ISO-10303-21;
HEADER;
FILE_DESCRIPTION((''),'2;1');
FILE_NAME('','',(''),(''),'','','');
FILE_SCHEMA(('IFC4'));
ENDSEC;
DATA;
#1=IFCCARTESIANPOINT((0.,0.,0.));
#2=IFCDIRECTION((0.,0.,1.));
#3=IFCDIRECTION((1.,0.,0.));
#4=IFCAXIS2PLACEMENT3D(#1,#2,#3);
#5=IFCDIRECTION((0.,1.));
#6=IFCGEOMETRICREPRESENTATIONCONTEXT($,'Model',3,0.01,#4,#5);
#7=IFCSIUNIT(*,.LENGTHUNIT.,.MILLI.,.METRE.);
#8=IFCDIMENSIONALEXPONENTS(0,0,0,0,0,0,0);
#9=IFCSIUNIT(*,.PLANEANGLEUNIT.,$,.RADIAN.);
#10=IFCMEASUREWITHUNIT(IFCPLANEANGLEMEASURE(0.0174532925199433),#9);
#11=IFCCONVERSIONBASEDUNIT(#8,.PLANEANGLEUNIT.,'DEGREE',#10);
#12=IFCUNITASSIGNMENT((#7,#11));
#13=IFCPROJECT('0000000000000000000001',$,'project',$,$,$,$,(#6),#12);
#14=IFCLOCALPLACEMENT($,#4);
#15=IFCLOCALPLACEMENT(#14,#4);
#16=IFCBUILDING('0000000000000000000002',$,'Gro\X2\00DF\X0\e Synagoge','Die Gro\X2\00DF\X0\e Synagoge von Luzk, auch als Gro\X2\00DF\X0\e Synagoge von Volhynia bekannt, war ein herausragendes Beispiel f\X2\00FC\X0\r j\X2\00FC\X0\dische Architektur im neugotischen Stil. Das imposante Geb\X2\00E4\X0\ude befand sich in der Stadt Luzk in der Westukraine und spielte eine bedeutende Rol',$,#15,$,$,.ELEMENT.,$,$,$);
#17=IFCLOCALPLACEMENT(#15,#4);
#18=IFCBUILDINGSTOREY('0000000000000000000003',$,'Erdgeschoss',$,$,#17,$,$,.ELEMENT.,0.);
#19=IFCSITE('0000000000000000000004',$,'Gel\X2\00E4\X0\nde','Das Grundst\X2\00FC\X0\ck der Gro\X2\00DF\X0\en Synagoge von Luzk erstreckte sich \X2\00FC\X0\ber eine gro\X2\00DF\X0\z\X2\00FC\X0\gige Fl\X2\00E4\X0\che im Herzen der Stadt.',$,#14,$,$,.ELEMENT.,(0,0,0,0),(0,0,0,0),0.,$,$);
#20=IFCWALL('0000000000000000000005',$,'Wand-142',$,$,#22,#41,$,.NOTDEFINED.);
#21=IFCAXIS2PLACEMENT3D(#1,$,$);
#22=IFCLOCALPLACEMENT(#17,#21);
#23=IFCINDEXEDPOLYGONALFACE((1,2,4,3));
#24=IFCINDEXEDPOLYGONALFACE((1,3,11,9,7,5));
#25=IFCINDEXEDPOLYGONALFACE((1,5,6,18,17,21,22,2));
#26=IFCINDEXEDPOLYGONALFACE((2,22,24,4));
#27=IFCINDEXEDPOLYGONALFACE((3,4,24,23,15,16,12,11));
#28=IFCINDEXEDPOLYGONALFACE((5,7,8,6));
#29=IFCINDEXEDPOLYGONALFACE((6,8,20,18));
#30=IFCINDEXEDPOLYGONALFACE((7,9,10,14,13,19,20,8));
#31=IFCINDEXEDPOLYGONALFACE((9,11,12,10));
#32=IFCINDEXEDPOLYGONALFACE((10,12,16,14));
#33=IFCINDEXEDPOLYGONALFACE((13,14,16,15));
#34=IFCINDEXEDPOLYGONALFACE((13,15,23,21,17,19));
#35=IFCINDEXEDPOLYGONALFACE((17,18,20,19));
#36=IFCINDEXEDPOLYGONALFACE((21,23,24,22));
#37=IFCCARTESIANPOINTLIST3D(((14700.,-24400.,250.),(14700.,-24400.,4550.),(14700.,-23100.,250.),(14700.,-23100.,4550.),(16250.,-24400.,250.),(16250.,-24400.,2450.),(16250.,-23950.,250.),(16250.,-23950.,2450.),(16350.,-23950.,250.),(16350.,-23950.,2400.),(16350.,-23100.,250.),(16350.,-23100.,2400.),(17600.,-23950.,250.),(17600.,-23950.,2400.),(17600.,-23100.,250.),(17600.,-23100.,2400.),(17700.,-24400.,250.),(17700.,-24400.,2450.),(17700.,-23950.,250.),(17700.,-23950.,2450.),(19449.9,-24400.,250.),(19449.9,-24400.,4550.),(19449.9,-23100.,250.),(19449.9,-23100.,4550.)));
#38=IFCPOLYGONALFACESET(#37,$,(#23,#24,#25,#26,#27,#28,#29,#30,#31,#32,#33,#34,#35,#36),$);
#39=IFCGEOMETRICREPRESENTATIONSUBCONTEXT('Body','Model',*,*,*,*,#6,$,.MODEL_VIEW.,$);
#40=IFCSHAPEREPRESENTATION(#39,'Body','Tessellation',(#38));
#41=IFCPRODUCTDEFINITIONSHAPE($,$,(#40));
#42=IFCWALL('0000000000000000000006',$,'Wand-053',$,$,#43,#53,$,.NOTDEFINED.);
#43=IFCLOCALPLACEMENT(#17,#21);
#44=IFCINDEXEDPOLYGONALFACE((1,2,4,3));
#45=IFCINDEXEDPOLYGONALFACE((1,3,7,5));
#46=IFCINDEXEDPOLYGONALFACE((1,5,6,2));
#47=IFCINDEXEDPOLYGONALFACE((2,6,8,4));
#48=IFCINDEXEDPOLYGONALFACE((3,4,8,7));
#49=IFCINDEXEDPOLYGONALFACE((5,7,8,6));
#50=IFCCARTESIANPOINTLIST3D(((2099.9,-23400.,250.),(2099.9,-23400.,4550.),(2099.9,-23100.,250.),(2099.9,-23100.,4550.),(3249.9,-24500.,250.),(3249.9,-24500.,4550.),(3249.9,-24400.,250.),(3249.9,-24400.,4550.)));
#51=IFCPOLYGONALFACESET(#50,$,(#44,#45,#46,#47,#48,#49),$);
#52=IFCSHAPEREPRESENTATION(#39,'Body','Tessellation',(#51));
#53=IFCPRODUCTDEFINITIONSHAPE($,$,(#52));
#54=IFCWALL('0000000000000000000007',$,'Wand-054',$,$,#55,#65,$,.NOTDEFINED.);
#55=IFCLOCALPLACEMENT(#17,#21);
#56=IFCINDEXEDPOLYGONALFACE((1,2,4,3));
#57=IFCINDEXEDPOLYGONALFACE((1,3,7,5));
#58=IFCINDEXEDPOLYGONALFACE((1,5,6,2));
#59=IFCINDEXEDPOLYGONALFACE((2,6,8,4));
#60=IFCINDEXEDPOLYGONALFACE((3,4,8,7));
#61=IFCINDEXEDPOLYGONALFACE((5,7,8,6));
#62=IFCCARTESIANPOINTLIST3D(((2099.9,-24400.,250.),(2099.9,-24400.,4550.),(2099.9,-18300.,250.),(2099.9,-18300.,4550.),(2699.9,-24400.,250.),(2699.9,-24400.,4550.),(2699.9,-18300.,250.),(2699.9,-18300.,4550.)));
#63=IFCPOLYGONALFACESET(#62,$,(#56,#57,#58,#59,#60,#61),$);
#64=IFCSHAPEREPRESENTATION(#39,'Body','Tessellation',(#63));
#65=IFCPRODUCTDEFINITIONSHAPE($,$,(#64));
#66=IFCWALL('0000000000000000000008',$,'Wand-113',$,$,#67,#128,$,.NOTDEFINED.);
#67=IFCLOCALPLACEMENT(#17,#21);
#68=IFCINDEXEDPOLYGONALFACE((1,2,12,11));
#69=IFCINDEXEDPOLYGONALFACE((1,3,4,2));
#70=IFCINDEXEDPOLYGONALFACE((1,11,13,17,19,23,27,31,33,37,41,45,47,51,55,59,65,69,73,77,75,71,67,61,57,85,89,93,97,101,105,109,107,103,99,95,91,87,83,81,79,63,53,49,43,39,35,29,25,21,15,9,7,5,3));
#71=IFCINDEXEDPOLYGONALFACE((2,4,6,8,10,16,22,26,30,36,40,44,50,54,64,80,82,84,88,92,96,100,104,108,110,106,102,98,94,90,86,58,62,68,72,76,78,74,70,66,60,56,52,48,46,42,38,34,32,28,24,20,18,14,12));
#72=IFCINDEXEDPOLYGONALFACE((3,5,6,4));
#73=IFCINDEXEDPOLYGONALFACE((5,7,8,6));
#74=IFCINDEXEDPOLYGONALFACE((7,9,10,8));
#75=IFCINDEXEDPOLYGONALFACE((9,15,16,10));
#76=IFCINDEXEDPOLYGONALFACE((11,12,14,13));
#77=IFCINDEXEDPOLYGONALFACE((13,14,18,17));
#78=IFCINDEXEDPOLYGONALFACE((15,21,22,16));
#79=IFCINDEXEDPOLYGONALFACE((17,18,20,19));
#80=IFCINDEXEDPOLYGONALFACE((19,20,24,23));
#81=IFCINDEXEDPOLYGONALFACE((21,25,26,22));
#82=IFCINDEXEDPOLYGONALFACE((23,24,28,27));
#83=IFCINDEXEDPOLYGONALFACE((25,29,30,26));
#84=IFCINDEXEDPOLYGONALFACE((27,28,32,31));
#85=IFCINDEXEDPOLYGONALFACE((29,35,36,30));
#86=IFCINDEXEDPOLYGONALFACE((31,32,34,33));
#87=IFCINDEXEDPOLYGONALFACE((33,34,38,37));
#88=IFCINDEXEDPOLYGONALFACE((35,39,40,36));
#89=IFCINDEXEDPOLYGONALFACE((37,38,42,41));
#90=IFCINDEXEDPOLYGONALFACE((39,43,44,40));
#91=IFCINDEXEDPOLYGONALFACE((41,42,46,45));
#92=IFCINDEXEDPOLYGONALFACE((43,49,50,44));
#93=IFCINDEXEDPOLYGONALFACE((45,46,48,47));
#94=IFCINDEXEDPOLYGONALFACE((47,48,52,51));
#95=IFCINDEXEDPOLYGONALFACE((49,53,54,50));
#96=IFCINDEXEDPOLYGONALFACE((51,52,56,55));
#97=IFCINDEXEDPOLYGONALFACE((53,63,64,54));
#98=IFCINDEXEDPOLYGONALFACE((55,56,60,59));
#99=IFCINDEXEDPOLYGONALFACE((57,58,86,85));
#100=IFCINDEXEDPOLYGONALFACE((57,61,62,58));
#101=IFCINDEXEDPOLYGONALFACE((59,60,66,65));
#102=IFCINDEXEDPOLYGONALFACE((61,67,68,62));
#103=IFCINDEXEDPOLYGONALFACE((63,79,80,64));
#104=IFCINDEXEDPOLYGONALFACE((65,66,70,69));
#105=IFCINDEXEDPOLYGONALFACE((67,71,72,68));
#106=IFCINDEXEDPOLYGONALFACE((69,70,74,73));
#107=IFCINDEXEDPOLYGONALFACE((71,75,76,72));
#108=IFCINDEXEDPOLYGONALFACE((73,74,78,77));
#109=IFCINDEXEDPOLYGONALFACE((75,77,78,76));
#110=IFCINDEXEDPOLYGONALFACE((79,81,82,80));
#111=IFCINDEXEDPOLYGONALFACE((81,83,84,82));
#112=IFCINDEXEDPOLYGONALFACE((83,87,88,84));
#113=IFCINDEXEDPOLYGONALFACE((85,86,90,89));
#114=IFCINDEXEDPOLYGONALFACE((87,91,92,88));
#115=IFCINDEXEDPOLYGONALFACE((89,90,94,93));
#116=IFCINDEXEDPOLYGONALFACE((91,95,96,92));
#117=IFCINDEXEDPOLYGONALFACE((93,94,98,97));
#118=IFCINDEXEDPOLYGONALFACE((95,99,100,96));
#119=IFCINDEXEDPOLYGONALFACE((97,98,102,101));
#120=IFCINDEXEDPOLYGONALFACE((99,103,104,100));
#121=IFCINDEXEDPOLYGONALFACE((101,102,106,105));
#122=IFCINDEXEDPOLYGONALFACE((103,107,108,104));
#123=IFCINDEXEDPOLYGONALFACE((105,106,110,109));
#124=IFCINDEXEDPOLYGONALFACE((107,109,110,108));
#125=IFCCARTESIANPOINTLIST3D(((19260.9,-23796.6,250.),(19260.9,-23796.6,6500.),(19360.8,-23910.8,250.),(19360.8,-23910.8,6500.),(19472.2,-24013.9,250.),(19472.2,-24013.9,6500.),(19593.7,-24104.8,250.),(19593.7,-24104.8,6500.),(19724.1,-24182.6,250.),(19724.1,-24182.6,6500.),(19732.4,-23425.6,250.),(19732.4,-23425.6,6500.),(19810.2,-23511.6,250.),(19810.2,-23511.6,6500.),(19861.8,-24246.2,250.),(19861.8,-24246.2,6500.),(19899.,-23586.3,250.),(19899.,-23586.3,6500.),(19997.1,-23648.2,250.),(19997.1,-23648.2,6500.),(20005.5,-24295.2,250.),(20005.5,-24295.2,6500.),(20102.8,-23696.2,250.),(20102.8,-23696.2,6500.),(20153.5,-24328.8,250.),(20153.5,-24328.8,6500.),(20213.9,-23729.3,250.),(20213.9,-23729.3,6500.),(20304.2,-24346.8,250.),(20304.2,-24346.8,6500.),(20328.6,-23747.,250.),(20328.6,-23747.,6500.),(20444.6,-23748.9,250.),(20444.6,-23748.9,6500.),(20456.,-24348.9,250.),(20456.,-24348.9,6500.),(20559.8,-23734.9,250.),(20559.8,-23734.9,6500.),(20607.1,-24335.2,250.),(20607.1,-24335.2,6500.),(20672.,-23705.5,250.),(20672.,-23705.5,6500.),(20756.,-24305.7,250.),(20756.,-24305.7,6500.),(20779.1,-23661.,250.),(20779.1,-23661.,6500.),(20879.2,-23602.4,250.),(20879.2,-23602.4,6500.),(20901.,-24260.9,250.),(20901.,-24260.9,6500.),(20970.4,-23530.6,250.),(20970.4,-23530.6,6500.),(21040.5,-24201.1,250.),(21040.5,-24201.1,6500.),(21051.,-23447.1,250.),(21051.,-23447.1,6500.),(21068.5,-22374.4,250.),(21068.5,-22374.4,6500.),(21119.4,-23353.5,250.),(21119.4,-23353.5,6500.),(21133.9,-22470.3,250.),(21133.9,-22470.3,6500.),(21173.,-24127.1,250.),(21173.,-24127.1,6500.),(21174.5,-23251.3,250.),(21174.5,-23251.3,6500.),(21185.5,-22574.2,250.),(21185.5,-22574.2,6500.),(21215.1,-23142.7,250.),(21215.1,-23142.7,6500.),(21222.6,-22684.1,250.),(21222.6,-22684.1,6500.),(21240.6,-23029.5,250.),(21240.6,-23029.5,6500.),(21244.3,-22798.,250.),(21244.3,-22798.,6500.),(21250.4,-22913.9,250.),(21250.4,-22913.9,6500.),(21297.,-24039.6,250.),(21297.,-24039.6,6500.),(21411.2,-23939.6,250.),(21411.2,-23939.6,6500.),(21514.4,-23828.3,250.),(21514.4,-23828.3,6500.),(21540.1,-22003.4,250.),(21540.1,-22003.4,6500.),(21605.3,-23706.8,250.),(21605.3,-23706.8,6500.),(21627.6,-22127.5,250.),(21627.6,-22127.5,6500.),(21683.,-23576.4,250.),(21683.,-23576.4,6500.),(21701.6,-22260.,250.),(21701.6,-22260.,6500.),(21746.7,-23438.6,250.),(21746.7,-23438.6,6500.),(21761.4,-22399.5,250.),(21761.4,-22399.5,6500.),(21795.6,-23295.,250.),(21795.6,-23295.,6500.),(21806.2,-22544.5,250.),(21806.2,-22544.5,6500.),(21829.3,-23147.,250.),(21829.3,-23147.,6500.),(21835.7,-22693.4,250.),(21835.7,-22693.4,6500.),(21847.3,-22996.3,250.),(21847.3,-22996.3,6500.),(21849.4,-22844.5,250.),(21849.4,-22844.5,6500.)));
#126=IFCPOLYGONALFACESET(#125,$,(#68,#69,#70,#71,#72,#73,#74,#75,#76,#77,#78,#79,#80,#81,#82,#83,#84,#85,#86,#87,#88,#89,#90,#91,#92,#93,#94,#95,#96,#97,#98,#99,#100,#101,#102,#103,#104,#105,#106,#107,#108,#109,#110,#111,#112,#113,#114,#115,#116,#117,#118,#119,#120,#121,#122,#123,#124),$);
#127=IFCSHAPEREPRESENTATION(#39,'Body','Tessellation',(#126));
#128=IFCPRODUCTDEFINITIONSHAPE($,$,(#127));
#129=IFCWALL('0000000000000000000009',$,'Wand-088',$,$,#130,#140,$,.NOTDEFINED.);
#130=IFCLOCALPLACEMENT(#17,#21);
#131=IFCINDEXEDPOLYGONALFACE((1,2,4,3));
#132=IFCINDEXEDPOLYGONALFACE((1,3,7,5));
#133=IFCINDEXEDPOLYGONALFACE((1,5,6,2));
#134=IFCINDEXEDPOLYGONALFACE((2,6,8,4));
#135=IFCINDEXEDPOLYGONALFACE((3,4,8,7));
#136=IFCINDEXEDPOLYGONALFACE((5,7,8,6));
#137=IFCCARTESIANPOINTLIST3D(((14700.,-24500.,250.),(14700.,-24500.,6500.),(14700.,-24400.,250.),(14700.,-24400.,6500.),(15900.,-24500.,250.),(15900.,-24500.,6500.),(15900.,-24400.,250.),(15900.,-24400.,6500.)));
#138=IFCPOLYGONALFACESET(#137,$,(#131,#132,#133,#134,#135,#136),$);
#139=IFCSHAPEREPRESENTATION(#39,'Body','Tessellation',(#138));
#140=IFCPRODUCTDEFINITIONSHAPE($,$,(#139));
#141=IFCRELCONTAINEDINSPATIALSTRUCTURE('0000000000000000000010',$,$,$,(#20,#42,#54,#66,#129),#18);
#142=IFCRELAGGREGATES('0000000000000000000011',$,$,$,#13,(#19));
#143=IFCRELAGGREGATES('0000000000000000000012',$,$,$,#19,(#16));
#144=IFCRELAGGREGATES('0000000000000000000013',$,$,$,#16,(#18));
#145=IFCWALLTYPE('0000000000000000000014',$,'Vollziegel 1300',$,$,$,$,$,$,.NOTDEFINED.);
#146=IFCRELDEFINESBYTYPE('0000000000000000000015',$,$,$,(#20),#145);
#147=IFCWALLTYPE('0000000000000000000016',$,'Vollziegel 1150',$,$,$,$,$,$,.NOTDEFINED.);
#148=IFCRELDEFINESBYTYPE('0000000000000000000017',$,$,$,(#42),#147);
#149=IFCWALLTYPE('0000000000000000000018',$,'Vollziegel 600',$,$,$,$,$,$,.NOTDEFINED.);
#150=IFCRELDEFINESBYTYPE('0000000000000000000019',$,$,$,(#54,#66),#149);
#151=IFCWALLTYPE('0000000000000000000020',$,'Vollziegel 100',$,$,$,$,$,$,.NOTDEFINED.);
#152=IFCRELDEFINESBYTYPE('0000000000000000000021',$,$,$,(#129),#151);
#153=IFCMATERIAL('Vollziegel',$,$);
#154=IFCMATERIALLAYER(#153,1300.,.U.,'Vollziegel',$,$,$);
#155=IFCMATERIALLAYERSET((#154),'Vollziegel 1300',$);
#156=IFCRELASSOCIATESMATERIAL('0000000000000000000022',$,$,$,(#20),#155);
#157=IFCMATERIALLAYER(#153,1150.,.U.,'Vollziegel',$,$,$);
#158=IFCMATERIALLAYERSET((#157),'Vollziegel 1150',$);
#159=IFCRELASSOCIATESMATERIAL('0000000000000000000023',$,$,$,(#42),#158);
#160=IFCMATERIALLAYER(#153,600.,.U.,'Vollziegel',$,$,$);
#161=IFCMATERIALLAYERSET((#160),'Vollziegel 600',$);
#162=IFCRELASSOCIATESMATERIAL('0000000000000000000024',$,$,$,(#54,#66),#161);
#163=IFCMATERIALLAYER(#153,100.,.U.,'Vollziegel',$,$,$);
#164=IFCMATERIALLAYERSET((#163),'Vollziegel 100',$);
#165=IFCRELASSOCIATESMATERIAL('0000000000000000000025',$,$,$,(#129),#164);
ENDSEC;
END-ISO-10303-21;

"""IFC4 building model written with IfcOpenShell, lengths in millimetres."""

from ifc_helpers import new_model, entity, si_unit, converted_unit, direction, frame, origin_with_axes, origin_2d_with_axis, place, context, subcontext, project, spatial, line, arc, indexed_curve, rectangle, outline, extrude, material, layer, layer_set, layer_usage, type_object, element, save


model = new_model("IFC4")

# Units and contexts
model_context = context("Model", 3, precision=0.01, world=origin_with_axes(), true_north=direction((0.0, 1.0)))
body_context = subcontext(model_context, "Body", "Model", "MODEL_VIEW")
ifc_project = project(units=[si_unit("LENGTHUNIT", "METRE", prefix="MILLI"), converted_unit("PLANEANGLEUNIT", "DEGREE", entity("IfcPlaneAngleMeasure", 0.0174532925199433), si_unit("PLANEANGLEUNIT", "RADIAN"), dimensions=[0, 0, 0, 0, 0, 0, 0])], contexts=[model_context])

# Site, building, storey
site_placement = place(None, origin_with_axes())
site = spatial("IfcSite", under=ifc_project, at=site_placement, Name="Gelände", Description="Das Grundstück der Großen Synagoge von Luzk erstreckte sich über eine großzügige Fläche im Herzen der Stadt.", CompositionType="ELEMENT", RefLatitude=(0, 0, 0, 0), RefLongitude=(0, 0, 0, 0), RefElevation=0.0)
building_placement = place(site_placement, origin_with_axes())
building = spatial("IfcBuilding", under=site, at=building_placement, Name="Große Synagoge", Description="Die Große Synagoge von Luzk, auch als Große Synagoge von Volhynia bekannt, war ein herausragendes Beispiel für jüdische Architektur im neugotischen Stil. Das imposante Gebäude befand sich in der Stadt Luzk in der Westukraine und spielte eine bedeutende Rol", CompositionType="ELEMENT")
storey_placement = place(building_placement, origin_with_axes())
storey = spatial("IfcBuildingStorey", under=building, at=storey_placement, Name="Erdgeschoss", CompositionType="ELEMENT", Elevation=0.0)

# Wall, opening
ifc_material_1 = material(Name="Vollziegel")
ifc_layer_1 = layer(ifc_material_1, 1300.0, ventilated="UNKNOWN", Name="Vollziegel")
ifc_layer_set_1 = layer_set([ifc_layer_1], Name="Vollziegel 1300")
ifc_layer_usage_1 = layer_usage(ifc_layer_set_1, "AXIS2", "POSITIVE", 0.0)
wall_type_1 = type_object("IfcWallType", Name="Vollziegel 1300", PredefinedType="NOTDEFINED")
wall_1_placement = place(storey_placement, frame((14700.0, -24400.0, 250.0), z_axis=(0.0, 0.0, 1.0), x_axis=(1.0, 0.0, 0.0)))
wall_1 = element("IfcWall", 1, at=wall_1_placement, inside=storey, type_object=wall_type_1, material=ifc_layer_usage_1, Name="Wand-142", PredefinedType="NOTDEFINED", context=body_context, shape_type="SweptSolid", body=[
    extrude(outline(indexed_curve([(0.0, 0.0), (4749.9, 0.0), (4749.9, 1300.0), (0.0, 1300.0)], segments=[line(1, 2, 3, 4, 1)])), origin_with_axes(), (0.0, 0.0, 1.0), 4300.0),
])
opening_placement = place(wall_1_placement, frame((2275.0, 0.0, 0.0), z_axis=(0.0, 0.0, 1.0), x_axis=(1.0, 0.0, 0.0)))
element("IfcOpeningElement", 2, at=opening_placement, cuts=wall_1, context=body_context, shape_type="SweptSolid", body=[
    extrude(rectangle(XDim=1250.0, YDim=2400.0, at=origin_2d_with_axis()), frame((0.0, 450.0, 950.0), z_axis=(0.0, -1.0, 0.0), x_axis=(1.0, 0.0, 0.0)), (0.0, 0.0, -1.0), 2150.0),
    extrude(rectangle(XDim=1450.0, YDim=2450.0, at=origin_2d_with_axis()), frame((0.0, 450.0, 975.0), z_axis=(0.0, 1.0, 0.0), x_axis=(1.0, 0.0, 0.0)), (0.0, 0.0, -1.0), 1750.0),
])

# Walls
ifc_layer_2 = layer(ifc_material_1, 1150.0, ventilated="UNKNOWN", Name="Vollziegel")
ifc_layer_set_2 = layer_set([ifc_layer_2], Name="Vollziegel 1150")
ifc_layer_usage_2 = layer_usage(ifc_layer_set_2, "AXIS2", "POSITIVE", -1150.0)
wall_type_2 = type_object("IfcWallType", Name="Vollziegel 1150", PredefinedType="NOTDEFINED")
wall_2_placement = place(storey_placement, frame((2099.9, -24500.0, 250.0), z_axis=(0.0, 0.0, 1.0), x_axis=(0.0, 1.0, 0.0)))
element("IfcWall", 3, at=wall_2_placement, inside=storey, type_object=wall_type_2, material=ifc_layer_usage_2, Name="Wand-053", PredefinedType="NOTDEFINED", context=body_context, shape_type="SweptSolid", body=[
    extrude(outline(indexed_curve([(0.0, -1150.0), (100.0, -1150.0), (1400.0, 0.0), (1100.0, 0.0)], segments=[line(1, 2, 3, 4, 1)])), origin_with_axes(), (0.0, 0.0, 1.0), 4300.0),
])
ifc_layer_3 = layer(ifc_material_1, 600.0, ventilated="UNKNOWN", Name="Vollziegel")
ifc_layer_set_3 = layer_set([ifc_layer_3], Name="Vollziegel 600")
ifc_layer_usage_3 = layer_usage(ifc_layer_set_3, "AXIS2", "POSITIVE", -600.0)
wall_type_3 = type_object("IfcWallType", Name="Vollziegel 600", PredefinedType="NOTDEFINED")
wall_3_placement = place(storey_placement, frame((2099.9, -24400.0, 250.0), z_axis=(0.0, 0.0, 1.0), x_axis=(0.0, 1.0, 0.0)))
element("IfcWall", 4, at=wall_3_placement, inside=storey, type_object=wall_type_3, material=ifc_layer_usage_3, Name="Wand-054", PredefinedType="NOTDEFINED", context=body_context, shape_type="SweptSolid", body=[
    extrude(outline(indexed_curve([(0.0, -600.0), (6100.0, -600.0), (6100.0, 0.0), (0.0, 0.0)], segments=[line(1, 2, 3, 4, 1)])), origin_with_axes(), (0.0, 0.0, 1.0), 4300.0),
])
ifc_layer_usage_4 = layer_usage(ifc_layer_set_3, "AXIS2", "POSITIVE", -600.0)
wall_4_placement = place(storey_placement, frame((19732.4, -23425.6, 250.0), z_axis=(0.0, 0.0, 1.0), x_axis=(0.618314, -0.785931, 0.0)))
element("IfcWall", 5, at=wall_4_placement, inside=storey, type_object=wall_type_3, material=ifc_layer_usage_4, Name="Wand-113", PredefinedType="NOTDEFINED", context=body_context, shape_type="SweptSolid", body=[
    extrude(outline(indexed_curve([(0.0, -600.0), (1450.0, 850.0), (0.0, 2300.0), (0.0, 1700.0), (850.0, 850.0), (0.0, 0.0)], segments=[arc(1, 2, 3), line(3, 4), arc(4, 5, 6), line(6, 1)])), origin_with_axes(), (0.0, 0.0, 1.0), 6250.0),
])
ifc_layer_4 = layer(ifc_material_1, 100.0, ventilated="UNKNOWN", Name="Vollziegel")
ifc_layer_set_4 = layer_set([ifc_layer_4], Name="Vollziegel 100")
ifc_layer_usage_5 = layer_usage(ifc_layer_set_4, "AXIS2", "POSITIVE", 0.0)
wall_type_4 = type_object("IfcWallType", Name="Vollziegel 100", PredefinedType="NOTDEFINED")
wall_5_placement = place(storey_placement, frame((15900.0, -24400.0, 250.0), z_axis=(0.0, 0.0, 1.0), x_axis=(-1.0, 0.0, 0.0)))
element("IfcWall", 6, at=wall_5_placement, inside=storey, type_object=wall_type_4, material=ifc_layer_usage_5, Name="Wand-088", PredefinedType="NOTDEFINED", context=body_context, shape_type="SweptSolid", body=[
    extrude(outline(indexed_curve([(0.0, 0.0), (1200.0, 0.0), (1200.0, 100.0), (0.0, 100.0)], segments=[line(1, 2, 3, 4, 1)])), origin_with_axes(), (0.0, 0.0, 1.0), 6250.0),
])

save(model, "model.ifc")
